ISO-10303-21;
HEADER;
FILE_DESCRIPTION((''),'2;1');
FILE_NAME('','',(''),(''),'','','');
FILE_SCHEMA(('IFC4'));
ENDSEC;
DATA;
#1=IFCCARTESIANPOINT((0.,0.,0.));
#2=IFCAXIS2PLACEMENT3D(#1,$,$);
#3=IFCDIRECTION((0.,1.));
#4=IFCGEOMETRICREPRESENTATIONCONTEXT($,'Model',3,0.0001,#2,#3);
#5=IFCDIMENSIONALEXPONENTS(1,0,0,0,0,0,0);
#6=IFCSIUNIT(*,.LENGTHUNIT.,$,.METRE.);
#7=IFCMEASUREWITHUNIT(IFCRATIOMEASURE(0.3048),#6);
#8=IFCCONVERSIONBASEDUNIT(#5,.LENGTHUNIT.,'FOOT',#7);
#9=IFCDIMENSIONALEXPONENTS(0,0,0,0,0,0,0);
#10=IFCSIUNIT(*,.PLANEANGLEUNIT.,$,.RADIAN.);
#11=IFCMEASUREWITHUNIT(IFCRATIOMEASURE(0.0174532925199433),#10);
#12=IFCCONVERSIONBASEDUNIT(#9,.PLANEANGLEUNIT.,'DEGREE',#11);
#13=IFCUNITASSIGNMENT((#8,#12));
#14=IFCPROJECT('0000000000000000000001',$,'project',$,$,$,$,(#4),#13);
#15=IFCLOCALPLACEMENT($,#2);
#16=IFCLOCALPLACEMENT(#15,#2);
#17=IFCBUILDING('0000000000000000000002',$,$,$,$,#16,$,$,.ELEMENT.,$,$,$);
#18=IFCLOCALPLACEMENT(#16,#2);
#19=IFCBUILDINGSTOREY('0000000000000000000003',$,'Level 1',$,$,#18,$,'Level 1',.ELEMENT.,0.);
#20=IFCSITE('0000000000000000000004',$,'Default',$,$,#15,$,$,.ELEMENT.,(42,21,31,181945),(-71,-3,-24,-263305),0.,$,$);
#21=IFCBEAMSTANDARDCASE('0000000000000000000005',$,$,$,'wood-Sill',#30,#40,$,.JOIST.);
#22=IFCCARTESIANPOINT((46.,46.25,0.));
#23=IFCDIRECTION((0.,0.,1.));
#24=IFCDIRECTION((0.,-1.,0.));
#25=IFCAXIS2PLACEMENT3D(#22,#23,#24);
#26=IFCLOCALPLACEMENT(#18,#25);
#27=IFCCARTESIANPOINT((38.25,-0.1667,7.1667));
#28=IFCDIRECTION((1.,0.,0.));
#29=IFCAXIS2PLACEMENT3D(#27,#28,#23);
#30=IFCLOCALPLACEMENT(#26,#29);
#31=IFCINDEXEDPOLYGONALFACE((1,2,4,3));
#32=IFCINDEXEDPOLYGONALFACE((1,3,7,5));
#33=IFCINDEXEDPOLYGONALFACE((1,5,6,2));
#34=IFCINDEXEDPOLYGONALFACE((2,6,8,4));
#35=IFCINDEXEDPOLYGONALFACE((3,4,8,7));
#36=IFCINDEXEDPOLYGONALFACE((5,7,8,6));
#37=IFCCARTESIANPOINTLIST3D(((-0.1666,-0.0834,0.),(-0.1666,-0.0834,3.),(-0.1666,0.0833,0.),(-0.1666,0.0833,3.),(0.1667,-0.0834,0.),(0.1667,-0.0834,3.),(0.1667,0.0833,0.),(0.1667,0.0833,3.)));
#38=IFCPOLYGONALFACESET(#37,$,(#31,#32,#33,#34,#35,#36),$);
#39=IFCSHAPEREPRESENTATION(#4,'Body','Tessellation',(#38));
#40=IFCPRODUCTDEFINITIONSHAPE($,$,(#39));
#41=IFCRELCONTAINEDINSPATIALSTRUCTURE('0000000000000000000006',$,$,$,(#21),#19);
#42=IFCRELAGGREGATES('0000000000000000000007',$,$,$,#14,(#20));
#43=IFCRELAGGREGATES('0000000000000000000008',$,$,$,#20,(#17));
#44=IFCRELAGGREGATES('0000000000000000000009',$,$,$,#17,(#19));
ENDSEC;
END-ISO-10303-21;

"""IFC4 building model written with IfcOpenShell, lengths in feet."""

from ifc_helpers import new_model, entity, si_unit, converted_unit, direction, frame, origin, origin_with_axes, place, context, project, spatial, rectangle, extrude, element, save


model = new_model("IFC4")

# Units and contexts
model_context = context("Model", 3, precision=0.0001, world=origin(), true_north=direction((0.0, 1.0)))
ifc_project = project(units=[converted_unit("LENGTHUNIT", "FOOT", entity("IfcRatioMeasure", 0.3048), si_unit("LENGTHUNIT", "METRE"), dimensions=[1, 0, 0, 0, 0, 0, 0]), converted_unit("PLANEANGLEUNIT", "DEGREE", entity("IfcRatioMeasure", 0.0174532925199433), si_unit("PLANEANGLEUNIT", "RADIAN"), dimensions=[0, 0, 0, 0, 0, 0, 0])], contexts=[model_context])

# Site, building, storey
site_placement = place(None, origin())
site = spatial("IfcSite", under=ifc_project, at=site_placement, Name="Default", CompositionType="ELEMENT", RefLatitude=(42, 21, 31, 181945), RefLongitude=(-71, -3, -24, -263305), RefElevation=0.0)
building_placement = place(site_placement, origin())
building = spatial("IfcBuilding", under=site, at=building_placement, CompositionType="ELEMENT")
storey_placement = place(building_placement, origin())
storey = spatial("IfcBuildingStorey", under=building, at=storey_placement, Name="Level 1", LongName="Level 1", CompositionType="ELEMENT", Elevation=0.0)

# Shared definitions
placement_1 = place(storey_placement, frame((46.0, 46.25, 0.0), z_axis=(0.0, 0.0, 1.0), x_axis=(0.0, -1.0, 0.0)))

# Beam
for number, where, z_axis, x_axis in (
    (1, (38.25, -0.1667, 7.1667), (1.0, 0.0, 0.0), (0.0, 0.0, 1.0)),
):
    element("IfcBeamStandardCase", number, at=place(placement_1, frame(where, z_axis=z_axis, x_axis=x_axis)), inside=storey, ObjectType="wood-Sill", PredefinedType="JOIST", context=model_context, shape_type="SweptSolid", body=[
        extrude(rectangle(XDim=0.3333, YDim=0.1667), origin_with_axes(), (0.0, 0.0, 1.0), 3.0),
    ])

save(model, "model.ifc")
